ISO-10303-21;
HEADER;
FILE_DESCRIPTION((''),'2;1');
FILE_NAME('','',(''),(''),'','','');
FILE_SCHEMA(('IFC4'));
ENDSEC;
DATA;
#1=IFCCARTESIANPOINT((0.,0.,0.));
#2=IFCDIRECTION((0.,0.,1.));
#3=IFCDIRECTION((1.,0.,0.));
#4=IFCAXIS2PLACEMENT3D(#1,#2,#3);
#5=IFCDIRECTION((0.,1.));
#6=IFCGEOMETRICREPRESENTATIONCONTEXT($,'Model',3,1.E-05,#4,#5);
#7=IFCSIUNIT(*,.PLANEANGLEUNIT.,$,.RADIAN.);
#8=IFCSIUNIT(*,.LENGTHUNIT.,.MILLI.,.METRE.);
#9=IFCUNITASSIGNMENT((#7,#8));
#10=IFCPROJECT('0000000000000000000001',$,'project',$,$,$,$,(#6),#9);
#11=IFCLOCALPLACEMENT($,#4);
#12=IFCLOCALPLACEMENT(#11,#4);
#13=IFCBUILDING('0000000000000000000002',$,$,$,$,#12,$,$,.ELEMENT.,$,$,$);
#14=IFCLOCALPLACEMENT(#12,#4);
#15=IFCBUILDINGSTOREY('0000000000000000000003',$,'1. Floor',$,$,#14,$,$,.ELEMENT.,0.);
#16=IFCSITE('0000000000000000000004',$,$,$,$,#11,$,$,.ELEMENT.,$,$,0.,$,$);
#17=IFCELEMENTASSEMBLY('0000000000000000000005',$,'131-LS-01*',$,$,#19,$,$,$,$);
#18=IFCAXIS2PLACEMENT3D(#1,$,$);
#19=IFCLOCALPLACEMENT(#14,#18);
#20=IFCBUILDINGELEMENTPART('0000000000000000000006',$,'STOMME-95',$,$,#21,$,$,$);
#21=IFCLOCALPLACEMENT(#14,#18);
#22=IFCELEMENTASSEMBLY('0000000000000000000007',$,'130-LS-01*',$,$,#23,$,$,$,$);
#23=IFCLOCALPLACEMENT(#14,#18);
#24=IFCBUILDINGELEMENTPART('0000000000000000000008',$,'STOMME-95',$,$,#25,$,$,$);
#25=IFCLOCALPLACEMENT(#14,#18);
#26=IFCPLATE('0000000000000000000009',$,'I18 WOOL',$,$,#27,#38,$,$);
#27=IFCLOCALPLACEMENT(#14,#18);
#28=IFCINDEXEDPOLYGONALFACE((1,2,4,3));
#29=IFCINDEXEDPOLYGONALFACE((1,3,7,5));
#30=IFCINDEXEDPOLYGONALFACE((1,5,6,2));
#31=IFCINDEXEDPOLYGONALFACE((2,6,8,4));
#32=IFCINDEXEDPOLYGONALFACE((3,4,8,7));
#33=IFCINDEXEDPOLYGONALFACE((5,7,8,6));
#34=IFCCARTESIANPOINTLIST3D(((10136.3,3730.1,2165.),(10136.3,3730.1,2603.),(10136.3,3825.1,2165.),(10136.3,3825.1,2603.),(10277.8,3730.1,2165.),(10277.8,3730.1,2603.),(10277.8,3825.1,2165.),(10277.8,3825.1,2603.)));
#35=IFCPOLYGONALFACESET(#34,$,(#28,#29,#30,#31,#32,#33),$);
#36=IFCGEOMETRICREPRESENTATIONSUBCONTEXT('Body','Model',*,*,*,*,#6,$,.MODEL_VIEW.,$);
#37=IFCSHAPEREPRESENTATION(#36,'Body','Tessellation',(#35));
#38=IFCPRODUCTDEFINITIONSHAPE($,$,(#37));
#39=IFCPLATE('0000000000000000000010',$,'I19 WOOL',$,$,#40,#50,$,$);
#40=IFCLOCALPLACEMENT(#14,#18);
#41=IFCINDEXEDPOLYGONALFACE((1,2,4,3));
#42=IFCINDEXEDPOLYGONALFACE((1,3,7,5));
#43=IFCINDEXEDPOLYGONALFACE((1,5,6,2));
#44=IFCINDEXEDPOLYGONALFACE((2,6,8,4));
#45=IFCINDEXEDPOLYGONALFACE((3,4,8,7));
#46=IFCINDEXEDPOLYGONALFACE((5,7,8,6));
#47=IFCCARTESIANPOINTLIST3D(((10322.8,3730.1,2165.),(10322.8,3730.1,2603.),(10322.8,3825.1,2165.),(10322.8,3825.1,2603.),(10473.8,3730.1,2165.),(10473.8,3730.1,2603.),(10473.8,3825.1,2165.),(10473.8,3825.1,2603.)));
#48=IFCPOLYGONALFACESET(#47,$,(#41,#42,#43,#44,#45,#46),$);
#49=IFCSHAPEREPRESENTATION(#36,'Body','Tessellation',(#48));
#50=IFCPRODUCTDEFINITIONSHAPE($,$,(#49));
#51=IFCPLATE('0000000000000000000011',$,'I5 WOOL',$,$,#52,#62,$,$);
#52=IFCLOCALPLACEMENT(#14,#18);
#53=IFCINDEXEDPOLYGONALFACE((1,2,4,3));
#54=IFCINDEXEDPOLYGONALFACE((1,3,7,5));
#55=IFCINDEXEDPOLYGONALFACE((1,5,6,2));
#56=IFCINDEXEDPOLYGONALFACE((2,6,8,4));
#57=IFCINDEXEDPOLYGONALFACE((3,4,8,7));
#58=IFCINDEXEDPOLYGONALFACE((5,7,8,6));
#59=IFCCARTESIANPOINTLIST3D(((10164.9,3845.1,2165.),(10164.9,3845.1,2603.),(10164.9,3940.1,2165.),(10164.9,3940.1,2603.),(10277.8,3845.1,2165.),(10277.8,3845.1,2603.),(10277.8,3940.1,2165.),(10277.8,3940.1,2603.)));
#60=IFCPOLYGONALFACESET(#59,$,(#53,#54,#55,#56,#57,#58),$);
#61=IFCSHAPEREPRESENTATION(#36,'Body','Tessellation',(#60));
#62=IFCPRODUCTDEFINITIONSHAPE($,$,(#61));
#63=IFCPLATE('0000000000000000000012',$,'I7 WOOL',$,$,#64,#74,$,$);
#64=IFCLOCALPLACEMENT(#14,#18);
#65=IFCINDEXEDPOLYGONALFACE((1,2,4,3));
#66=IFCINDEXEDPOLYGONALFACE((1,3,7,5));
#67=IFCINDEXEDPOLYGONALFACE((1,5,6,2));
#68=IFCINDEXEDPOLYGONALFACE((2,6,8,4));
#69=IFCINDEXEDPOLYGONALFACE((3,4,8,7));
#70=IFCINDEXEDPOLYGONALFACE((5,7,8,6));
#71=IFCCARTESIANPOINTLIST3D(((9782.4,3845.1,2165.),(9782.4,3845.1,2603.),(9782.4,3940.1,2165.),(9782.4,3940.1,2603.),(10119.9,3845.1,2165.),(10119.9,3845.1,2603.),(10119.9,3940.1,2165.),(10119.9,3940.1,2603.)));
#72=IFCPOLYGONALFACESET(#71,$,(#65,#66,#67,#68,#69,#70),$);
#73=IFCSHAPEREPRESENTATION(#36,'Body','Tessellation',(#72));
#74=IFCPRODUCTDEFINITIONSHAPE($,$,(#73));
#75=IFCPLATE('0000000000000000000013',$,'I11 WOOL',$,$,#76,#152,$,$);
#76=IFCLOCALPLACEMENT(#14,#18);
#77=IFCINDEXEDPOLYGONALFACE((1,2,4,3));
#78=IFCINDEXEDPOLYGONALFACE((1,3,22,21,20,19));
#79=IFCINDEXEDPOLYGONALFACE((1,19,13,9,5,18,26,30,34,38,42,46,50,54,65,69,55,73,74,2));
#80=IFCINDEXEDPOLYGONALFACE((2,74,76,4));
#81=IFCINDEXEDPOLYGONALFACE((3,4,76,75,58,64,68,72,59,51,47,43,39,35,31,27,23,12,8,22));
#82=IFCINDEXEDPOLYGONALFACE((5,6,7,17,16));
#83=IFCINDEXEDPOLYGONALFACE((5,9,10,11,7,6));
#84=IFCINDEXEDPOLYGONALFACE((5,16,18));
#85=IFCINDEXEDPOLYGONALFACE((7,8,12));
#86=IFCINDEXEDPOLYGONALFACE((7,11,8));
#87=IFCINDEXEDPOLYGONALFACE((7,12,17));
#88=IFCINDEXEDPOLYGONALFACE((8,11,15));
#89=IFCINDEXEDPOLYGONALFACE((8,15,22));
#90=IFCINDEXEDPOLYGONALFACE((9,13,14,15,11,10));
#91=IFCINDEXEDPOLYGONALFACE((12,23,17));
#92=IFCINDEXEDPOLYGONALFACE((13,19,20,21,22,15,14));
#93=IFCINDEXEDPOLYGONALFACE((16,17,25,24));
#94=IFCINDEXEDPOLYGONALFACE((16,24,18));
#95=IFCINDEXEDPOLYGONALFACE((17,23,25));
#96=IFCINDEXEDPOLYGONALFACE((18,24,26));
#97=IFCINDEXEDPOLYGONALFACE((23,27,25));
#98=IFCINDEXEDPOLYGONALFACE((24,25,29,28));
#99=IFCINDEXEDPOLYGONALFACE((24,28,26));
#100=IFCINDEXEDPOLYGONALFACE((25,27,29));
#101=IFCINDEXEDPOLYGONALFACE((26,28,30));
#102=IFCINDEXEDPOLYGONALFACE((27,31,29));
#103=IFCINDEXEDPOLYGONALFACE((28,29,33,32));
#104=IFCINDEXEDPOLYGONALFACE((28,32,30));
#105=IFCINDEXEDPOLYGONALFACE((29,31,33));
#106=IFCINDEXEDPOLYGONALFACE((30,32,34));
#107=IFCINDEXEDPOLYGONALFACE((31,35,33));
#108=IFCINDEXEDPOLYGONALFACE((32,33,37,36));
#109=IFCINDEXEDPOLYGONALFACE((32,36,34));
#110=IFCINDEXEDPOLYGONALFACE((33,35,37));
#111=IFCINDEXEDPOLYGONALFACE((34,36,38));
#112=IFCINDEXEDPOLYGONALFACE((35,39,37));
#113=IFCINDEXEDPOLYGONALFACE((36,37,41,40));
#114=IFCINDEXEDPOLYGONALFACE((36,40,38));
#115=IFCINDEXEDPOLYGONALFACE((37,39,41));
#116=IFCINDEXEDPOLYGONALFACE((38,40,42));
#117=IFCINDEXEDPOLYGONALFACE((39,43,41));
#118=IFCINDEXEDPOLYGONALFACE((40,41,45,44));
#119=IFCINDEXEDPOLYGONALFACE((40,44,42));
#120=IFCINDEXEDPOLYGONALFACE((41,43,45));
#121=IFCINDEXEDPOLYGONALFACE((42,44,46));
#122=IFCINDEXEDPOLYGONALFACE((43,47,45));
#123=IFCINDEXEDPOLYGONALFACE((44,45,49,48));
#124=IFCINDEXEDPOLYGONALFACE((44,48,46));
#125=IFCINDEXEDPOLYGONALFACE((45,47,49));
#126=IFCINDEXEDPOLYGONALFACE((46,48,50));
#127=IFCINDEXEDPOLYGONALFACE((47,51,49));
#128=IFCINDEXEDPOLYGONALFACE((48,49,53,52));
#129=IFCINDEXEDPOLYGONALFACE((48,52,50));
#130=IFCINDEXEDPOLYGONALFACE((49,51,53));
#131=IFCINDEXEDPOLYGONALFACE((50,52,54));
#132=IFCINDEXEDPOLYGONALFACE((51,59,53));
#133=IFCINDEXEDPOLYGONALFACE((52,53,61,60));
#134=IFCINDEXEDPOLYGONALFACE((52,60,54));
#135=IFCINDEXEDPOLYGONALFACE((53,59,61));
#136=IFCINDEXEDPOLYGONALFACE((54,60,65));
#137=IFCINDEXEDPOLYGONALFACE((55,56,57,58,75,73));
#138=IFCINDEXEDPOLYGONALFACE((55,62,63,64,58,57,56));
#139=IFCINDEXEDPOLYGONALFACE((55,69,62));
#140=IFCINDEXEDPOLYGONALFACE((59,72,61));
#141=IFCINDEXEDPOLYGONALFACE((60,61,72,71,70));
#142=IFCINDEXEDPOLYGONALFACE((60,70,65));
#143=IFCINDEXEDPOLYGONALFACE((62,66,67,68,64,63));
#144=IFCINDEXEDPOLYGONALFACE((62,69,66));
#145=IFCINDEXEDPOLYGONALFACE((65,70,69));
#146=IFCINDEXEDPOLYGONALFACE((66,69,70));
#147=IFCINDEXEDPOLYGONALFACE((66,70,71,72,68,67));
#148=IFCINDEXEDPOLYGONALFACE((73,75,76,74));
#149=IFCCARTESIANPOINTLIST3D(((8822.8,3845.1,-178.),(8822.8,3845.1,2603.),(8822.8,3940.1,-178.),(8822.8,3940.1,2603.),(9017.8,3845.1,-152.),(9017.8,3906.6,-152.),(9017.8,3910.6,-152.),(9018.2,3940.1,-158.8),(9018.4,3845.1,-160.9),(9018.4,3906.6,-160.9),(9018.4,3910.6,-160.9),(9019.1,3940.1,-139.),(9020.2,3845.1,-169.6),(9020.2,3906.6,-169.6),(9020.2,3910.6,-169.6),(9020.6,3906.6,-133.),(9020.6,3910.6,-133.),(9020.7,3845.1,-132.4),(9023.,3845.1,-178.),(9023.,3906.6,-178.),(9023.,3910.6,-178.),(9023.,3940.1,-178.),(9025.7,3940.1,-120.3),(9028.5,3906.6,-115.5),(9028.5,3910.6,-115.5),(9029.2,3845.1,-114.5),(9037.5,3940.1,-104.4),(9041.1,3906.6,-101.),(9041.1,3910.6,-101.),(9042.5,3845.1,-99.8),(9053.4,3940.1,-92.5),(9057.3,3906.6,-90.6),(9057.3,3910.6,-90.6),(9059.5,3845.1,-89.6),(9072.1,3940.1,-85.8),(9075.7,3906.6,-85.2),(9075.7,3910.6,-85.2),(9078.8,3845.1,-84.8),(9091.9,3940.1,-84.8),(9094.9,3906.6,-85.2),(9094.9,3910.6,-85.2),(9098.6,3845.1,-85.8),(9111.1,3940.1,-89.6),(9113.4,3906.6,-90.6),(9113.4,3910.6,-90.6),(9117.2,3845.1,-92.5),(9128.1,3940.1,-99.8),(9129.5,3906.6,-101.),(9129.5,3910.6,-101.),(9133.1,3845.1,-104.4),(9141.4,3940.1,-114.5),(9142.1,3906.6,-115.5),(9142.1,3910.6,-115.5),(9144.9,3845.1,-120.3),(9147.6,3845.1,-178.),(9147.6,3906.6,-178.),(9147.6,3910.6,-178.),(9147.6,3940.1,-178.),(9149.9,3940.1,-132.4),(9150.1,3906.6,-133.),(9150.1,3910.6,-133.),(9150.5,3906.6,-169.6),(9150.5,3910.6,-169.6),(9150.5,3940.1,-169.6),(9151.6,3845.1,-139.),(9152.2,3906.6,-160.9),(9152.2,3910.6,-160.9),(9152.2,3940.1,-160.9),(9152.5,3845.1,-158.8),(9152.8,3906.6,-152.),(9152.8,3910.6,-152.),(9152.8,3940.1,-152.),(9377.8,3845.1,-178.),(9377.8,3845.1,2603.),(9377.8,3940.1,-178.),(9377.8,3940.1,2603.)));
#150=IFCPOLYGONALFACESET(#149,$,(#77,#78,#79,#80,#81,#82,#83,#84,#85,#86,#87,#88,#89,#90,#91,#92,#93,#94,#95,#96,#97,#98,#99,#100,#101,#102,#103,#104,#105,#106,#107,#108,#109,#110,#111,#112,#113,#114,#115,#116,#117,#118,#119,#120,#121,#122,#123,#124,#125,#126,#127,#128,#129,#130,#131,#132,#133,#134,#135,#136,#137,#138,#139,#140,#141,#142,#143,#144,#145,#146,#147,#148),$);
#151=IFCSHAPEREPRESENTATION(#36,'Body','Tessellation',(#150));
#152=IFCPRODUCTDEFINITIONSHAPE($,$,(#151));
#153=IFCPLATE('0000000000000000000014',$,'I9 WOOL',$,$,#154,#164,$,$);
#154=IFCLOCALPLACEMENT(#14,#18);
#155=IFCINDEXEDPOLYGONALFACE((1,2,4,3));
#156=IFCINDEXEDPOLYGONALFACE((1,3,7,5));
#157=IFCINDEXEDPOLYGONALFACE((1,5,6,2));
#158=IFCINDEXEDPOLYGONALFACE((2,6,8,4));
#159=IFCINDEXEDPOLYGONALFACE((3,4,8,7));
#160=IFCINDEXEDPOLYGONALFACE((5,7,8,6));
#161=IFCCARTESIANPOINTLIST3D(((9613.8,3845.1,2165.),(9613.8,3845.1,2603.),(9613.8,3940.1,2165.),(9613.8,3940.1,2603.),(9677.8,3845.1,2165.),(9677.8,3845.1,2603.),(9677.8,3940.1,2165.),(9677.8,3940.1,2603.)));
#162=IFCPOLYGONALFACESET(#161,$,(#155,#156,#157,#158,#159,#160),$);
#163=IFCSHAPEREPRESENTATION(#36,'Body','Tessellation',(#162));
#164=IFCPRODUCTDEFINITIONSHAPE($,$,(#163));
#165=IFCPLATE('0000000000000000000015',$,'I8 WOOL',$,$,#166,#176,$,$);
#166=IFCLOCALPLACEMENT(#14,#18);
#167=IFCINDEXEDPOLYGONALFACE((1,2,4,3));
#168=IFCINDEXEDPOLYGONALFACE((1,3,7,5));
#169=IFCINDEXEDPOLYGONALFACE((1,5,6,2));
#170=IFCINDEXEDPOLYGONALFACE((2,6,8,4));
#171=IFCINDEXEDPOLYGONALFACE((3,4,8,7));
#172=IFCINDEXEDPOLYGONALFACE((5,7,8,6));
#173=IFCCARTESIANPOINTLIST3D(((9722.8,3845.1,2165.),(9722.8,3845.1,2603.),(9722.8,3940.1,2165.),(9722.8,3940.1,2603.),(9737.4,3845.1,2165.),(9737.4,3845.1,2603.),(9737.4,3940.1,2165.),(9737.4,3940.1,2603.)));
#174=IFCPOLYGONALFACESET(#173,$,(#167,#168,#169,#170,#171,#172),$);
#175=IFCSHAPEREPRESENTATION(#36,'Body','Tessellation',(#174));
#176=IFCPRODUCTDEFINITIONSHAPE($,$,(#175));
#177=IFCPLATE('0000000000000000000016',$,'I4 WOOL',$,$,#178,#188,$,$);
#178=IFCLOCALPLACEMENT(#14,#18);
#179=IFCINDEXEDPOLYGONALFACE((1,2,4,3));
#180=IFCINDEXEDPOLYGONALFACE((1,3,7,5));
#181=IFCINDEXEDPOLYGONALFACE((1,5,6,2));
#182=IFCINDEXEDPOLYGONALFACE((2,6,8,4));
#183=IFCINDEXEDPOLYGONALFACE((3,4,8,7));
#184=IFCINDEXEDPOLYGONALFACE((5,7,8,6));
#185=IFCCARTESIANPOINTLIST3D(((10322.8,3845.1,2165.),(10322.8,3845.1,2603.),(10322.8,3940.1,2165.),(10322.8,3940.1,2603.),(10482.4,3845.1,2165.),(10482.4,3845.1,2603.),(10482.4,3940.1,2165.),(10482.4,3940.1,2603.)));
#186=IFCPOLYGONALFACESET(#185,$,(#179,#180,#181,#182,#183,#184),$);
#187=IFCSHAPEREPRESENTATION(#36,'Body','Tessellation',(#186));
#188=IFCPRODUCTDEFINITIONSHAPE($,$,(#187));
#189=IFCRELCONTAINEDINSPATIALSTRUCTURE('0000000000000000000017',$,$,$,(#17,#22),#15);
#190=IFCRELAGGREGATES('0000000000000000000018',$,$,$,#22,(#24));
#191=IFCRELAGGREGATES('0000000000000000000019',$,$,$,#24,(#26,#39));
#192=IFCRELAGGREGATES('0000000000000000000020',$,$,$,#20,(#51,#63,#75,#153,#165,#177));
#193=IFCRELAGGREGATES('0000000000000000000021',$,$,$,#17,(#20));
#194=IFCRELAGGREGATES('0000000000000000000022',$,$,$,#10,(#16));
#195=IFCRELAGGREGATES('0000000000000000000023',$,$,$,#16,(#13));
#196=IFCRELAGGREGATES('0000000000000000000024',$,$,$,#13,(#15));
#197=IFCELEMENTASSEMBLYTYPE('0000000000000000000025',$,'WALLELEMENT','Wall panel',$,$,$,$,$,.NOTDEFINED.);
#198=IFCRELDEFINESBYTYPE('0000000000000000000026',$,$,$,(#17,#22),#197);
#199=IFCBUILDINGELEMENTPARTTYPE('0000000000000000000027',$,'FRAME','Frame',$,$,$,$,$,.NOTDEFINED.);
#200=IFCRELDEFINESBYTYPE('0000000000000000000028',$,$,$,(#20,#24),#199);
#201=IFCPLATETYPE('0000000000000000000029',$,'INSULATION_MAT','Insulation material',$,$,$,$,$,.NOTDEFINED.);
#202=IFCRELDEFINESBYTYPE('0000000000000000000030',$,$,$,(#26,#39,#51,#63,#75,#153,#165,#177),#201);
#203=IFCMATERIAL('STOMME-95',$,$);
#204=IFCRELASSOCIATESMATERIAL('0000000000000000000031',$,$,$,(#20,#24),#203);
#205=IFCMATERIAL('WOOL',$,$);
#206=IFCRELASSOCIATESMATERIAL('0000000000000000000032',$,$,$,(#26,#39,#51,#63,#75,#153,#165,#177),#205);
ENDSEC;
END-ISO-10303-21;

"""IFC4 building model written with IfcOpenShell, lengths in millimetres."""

from ifc_helpers import new_model, si_unit, direction, frame, origin_with_axes, origin_2d_with_axis, place, context, subcontext, project, spatial, rectangle, circle, extrude, boolean, material, type_object, element, aggregate, save


model = new_model("IFC4")

# Units and contexts
model_context = context("Model", 3, precision=1e-05, world=origin_with_axes(), true_north=direction((0.0, 1.0)))
body_context = subcontext(model_context, "Body", "Model", "MODEL_VIEW")
ifc_project = project(units=[si_unit("PLANEANGLEUNIT", "RADIAN"), si_unit("LENGTHUNIT", "METRE", prefix="MILLI")], contexts=[model_context])

# Site, building, storey
site_placement = place(None, origin_with_axes())
site = spatial("IfcSite", under=ifc_project, at=site_placement, CompositionType="ELEMENT", RefElevation=0.0)
building_placement = place(site_placement, origin_with_axes())
building = spatial("IfcBuilding", under=site, at=building_placement, CompositionType="ELEMENT")
storey_placement = place(building_placement, origin_with_axes())
storey = spatial("IfcBuildingStorey", under=building, at=storey_placement, Name="1. Floor", CompositionType="ELEMENT", Elevation=0.0)

# Element assembly, building element part
element_assembly_type_1 = type_object("IfcElementAssemblyType", Name="WALLELEMENT", Description="Wall panel", PredefinedType="NOTDEFINED")
assembly_1_placement = place(storey_placement, origin_with_axes())
assembly_1 = element("IfcElementAssembly", 1, at=assembly_1_placement, inside=storey, type_object=element_assembly_type_1, Name="131-LS-01*")
ifc_material_1 = material(Name="STOMME-95")
building_element_part_type = type_object("IfcBuildingElementPartType", Name="FRAME", Description="Frame", PredefinedType="NOTDEFINED")
building_element_part_1_placement = place(storey_placement, origin_with_axes())
building_element_part_1 = element("IfcBuildingElementPart", 2, at=building_element_part_1_placement, type_object=building_element_part_type, material=ifc_material_1, Name="STOMME-95")

# Element assembly, building element part, plates
assembly_2_placement = place(storey_placement, origin_with_axes())
assembly_2 = element("IfcElementAssembly", 3, at=assembly_2_placement, inside=storey, type_object=element_assembly_type_1, Name="130-LS-01*")
building_element_part_2_placement = place(storey_placement, origin_with_axes())
building_element_part_2 = element("IfcBuildingElementPart", 4, at=building_element_part_2_placement, type_object=building_element_part_type, material=ifc_material_1, Name="STOMME-95")
aggregate(assembly_2, [building_element_part_2])
ifc_material_2 = material(Name="WOOL")
plate_type_1 = type_object("IfcPlateType", Name="INSULATION_MAT", Description="Insulation material", PredefinedType="NOTDEFINED")
plate_1_placement = place(storey_placement, frame((10207.0, 3825.1, 2384.0), z_axis=(0.0, 1.0, 0.0), x_axis=(-1.0, 0.0, 0.0)))
plate_1 = element("IfcPlate", 5, at=plate_1_placement, type_object=plate_type_1, material=ifc_material_2, Name="I18 WOOL", context=body_context, shape_type="SweptSolid", body=[
    extrude(rectangle(XDim=95.0, YDim=141.5, at=origin_2d_with_axis()), frame((0.0, -219.0, -47.5), z_axis=(0.0, 1.0, 0.0), x_axis=(0.0, 0.0, 1.0)), (0.0, 0.0, 1.0), 438.0),
])
plate_2_placement = place(storey_placement, frame((10398.3, 3825.1, 2384.0), z_axis=(0.0, 1.0, 0.0), x_axis=(-1.0, 0.0, 0.0)))
plate_2 = element("IfcPlate", 6, at=plate_2_placement, type_object=plate_type_1, material=ifc_material_2, Name="I19 WOOL", context=body_context, shape_type="SweptSolid", body=[
    extrude(rectangle(XDim=95.0, YDim=151.0, at=origin_2d_with_axis()), frame((0.0, -219.0, -47.5), z_axis=(0.0, 1.0, 0.0), x_axis=(0.0, 0.0, 1.0)), (0.0, 0.0, 1.0), 438.0),
])
aggregate(building_element_part_2, [plate_1, plate_2])

# Plates
plate_3_placement = place(storey_placement, frame((10221.4, 3845.1, 2384.0), z_axis=(0.0, -1.0, 0.0), x_axis=(1.0, 0.0, 0.0)))
plate_3 = element("IfcPlate", 7, at=plate_3_placement, type_object=plate_type_1, material=ifc_material_2, Name="I5 WOOL", context=body_context, shape_type="SweptSolid", body=[
    extrude(rectangle(XDim=95.0, YDim=112.9, at=origin_2d_with_axis()), frame((0.0, -219.0, -47.5), z_axis=(0.0, 1.0, 0.0), x_axis=(0.0, 0.0, 1.0)), (0.0, 0.0, 1.0), 438.0),
])
plate_4_placement = place(storey_placement, frame((9951.1, 3845.1, 2384.0), z_axis=(0.0, -1.0, 0.0), x_axis=(1.0, 0.0, 0.0)))
plate_4 = element("IfcPlate", 8, at=plate_4_placement, type_object=plate_type_1, material=ifc_material_2, Name="I7 WOOL", context=body_context, shape_type="SweptSolid", body=[
    extrude(rectangle(XDim=95.0, YDim=337.5, at=origin_2d_with_axis()), frame((0.0, -219.0, -47.5), z_axis=(0.0, 1.0, 0.0), x_axis=(0.0, 0.0, 1.0)), (0.0, 0.0, 1.0), 438.0),
])
plate_5_placement = place(storey_placement, frame((9100.3, 3845.1, 1212.5), z_axis=(0.0, -1.0, 0.0), x_axis=(1.0, 0.0, 0.0)))
plate_5 = element("IfcPlate", 9, at=plate_5_placement, type_object=plate_type_1, material=ifc_material_2, Name="I11 WOOL", context=body_context, shape_type="CSG", body=[
    boolean("DIFFERENCE", boolean("DIFFERENCE", extrude(rectangle(XDim=95.0, YDim=555.0, at=origin_2d_with_axis()), frame((0.0, -1390.5, -47.5), z_axis=(0.0, 1.0, 0.0), x_axis=(0.0, 0.0, 1.0)), (0.0, 0.0, 1.0), 2781.0), extrude(circle(Radius=67.5, at=origin_2d_with_axis()), frame((-15.0, -1364.5, -126.0), z_axis=(0.0, 0.0, -1.0), x_axis=(1.0, 0.0, 0.0)), (0.0, 0.0, -1.0), 64.5)), extrude(circle(Radius=67.5, at=origin_2d_with_axis()), frame((-15.0, -1364.5, 1.0), z_axis=(0.0, 0.0, 1.0), x_axis=(-1.0, 0.0, 0.0)), (0.0, 0.0, -1.0), 66.5)),
])
plate_6_placement = place(storey_placement, frame((9645.8, 3845.1, 2384.0), z_axis=(0.0, -1.0, 0.0), x_axis=(1.0, 0.0, 0.0)))
plate_6 = element("IfcPlate", 10, at=plate_6_placement, type_object=plate_type_1, material=ifc_material_2, Name="I9 WOOL", context=body_context, shape_type="SweptSolid", body=[
    extrude(rectangle(XDim=95.0, YDim=64.0, at=origin_2d_with_axis()), frame((0.0, -219.0, -47.5), z_axis=(0.0, 1.0, 0.0), x_axis=(0.0, 0.0, 1.0)), (0.0, 0.0, 1.0), 438.0),
])
plate_7_placement = place(storey_placement, frame((9730.1, 3845.1, 2384.0), z_axis=(0.0, -1.0, 0.0), x_axis=(1.0, 0.0, 0.0)))
plate_7 = element("IfcPlate", 11, at=plate_7_placement, type_object=plate_type_1, material=ifc_material_2, Name="I8 WOOL", context=body_context, shape_type="SweptSolid", body=[
    extrude(rectangle(XDim=95.0, YDim=14.6, at=origin_2d_with_axis()), frame((0.0, -219.0, -47.5), z_axis=(0.0, 1.0, 0.0), x_axis=(0.0, 0.0, 1.0)), (0.0, 0.0, 1.0), 438.0),
])
plate_8_placement = place(storey_placement, frame((10402.6, 3845.1, 2384.0), z_axis=(0.0, -1.0, 0.0), x_axis=(1.0, 0.0, 0.0)))
plate_8 = element("IfcPlate", 12, at=plate_8_placement, type_object=plate_type_1, material=ifc_material_2, Name="I4 WOOL", context=body_context, shape_type="SweptSolid", body=[
    extrude(rectangle(XDim=95.0, YDim=159.6, at=origin_2d_with_axis()), frame((0.0, -219.0, -47.5), z_axis=(0.0, 1.0, 0.0), x_axis=(0.0, 0.0, 1.0)), (0.0, 0.0, 1.0), 438.0),
])
aggregate(building_element_part_1, [plate_3, plate_4, plate_5, plate_6, plate_7, plate_8])

aggregate(assembly_1, [building_element_part_1])

save(model, "model.ifc")
